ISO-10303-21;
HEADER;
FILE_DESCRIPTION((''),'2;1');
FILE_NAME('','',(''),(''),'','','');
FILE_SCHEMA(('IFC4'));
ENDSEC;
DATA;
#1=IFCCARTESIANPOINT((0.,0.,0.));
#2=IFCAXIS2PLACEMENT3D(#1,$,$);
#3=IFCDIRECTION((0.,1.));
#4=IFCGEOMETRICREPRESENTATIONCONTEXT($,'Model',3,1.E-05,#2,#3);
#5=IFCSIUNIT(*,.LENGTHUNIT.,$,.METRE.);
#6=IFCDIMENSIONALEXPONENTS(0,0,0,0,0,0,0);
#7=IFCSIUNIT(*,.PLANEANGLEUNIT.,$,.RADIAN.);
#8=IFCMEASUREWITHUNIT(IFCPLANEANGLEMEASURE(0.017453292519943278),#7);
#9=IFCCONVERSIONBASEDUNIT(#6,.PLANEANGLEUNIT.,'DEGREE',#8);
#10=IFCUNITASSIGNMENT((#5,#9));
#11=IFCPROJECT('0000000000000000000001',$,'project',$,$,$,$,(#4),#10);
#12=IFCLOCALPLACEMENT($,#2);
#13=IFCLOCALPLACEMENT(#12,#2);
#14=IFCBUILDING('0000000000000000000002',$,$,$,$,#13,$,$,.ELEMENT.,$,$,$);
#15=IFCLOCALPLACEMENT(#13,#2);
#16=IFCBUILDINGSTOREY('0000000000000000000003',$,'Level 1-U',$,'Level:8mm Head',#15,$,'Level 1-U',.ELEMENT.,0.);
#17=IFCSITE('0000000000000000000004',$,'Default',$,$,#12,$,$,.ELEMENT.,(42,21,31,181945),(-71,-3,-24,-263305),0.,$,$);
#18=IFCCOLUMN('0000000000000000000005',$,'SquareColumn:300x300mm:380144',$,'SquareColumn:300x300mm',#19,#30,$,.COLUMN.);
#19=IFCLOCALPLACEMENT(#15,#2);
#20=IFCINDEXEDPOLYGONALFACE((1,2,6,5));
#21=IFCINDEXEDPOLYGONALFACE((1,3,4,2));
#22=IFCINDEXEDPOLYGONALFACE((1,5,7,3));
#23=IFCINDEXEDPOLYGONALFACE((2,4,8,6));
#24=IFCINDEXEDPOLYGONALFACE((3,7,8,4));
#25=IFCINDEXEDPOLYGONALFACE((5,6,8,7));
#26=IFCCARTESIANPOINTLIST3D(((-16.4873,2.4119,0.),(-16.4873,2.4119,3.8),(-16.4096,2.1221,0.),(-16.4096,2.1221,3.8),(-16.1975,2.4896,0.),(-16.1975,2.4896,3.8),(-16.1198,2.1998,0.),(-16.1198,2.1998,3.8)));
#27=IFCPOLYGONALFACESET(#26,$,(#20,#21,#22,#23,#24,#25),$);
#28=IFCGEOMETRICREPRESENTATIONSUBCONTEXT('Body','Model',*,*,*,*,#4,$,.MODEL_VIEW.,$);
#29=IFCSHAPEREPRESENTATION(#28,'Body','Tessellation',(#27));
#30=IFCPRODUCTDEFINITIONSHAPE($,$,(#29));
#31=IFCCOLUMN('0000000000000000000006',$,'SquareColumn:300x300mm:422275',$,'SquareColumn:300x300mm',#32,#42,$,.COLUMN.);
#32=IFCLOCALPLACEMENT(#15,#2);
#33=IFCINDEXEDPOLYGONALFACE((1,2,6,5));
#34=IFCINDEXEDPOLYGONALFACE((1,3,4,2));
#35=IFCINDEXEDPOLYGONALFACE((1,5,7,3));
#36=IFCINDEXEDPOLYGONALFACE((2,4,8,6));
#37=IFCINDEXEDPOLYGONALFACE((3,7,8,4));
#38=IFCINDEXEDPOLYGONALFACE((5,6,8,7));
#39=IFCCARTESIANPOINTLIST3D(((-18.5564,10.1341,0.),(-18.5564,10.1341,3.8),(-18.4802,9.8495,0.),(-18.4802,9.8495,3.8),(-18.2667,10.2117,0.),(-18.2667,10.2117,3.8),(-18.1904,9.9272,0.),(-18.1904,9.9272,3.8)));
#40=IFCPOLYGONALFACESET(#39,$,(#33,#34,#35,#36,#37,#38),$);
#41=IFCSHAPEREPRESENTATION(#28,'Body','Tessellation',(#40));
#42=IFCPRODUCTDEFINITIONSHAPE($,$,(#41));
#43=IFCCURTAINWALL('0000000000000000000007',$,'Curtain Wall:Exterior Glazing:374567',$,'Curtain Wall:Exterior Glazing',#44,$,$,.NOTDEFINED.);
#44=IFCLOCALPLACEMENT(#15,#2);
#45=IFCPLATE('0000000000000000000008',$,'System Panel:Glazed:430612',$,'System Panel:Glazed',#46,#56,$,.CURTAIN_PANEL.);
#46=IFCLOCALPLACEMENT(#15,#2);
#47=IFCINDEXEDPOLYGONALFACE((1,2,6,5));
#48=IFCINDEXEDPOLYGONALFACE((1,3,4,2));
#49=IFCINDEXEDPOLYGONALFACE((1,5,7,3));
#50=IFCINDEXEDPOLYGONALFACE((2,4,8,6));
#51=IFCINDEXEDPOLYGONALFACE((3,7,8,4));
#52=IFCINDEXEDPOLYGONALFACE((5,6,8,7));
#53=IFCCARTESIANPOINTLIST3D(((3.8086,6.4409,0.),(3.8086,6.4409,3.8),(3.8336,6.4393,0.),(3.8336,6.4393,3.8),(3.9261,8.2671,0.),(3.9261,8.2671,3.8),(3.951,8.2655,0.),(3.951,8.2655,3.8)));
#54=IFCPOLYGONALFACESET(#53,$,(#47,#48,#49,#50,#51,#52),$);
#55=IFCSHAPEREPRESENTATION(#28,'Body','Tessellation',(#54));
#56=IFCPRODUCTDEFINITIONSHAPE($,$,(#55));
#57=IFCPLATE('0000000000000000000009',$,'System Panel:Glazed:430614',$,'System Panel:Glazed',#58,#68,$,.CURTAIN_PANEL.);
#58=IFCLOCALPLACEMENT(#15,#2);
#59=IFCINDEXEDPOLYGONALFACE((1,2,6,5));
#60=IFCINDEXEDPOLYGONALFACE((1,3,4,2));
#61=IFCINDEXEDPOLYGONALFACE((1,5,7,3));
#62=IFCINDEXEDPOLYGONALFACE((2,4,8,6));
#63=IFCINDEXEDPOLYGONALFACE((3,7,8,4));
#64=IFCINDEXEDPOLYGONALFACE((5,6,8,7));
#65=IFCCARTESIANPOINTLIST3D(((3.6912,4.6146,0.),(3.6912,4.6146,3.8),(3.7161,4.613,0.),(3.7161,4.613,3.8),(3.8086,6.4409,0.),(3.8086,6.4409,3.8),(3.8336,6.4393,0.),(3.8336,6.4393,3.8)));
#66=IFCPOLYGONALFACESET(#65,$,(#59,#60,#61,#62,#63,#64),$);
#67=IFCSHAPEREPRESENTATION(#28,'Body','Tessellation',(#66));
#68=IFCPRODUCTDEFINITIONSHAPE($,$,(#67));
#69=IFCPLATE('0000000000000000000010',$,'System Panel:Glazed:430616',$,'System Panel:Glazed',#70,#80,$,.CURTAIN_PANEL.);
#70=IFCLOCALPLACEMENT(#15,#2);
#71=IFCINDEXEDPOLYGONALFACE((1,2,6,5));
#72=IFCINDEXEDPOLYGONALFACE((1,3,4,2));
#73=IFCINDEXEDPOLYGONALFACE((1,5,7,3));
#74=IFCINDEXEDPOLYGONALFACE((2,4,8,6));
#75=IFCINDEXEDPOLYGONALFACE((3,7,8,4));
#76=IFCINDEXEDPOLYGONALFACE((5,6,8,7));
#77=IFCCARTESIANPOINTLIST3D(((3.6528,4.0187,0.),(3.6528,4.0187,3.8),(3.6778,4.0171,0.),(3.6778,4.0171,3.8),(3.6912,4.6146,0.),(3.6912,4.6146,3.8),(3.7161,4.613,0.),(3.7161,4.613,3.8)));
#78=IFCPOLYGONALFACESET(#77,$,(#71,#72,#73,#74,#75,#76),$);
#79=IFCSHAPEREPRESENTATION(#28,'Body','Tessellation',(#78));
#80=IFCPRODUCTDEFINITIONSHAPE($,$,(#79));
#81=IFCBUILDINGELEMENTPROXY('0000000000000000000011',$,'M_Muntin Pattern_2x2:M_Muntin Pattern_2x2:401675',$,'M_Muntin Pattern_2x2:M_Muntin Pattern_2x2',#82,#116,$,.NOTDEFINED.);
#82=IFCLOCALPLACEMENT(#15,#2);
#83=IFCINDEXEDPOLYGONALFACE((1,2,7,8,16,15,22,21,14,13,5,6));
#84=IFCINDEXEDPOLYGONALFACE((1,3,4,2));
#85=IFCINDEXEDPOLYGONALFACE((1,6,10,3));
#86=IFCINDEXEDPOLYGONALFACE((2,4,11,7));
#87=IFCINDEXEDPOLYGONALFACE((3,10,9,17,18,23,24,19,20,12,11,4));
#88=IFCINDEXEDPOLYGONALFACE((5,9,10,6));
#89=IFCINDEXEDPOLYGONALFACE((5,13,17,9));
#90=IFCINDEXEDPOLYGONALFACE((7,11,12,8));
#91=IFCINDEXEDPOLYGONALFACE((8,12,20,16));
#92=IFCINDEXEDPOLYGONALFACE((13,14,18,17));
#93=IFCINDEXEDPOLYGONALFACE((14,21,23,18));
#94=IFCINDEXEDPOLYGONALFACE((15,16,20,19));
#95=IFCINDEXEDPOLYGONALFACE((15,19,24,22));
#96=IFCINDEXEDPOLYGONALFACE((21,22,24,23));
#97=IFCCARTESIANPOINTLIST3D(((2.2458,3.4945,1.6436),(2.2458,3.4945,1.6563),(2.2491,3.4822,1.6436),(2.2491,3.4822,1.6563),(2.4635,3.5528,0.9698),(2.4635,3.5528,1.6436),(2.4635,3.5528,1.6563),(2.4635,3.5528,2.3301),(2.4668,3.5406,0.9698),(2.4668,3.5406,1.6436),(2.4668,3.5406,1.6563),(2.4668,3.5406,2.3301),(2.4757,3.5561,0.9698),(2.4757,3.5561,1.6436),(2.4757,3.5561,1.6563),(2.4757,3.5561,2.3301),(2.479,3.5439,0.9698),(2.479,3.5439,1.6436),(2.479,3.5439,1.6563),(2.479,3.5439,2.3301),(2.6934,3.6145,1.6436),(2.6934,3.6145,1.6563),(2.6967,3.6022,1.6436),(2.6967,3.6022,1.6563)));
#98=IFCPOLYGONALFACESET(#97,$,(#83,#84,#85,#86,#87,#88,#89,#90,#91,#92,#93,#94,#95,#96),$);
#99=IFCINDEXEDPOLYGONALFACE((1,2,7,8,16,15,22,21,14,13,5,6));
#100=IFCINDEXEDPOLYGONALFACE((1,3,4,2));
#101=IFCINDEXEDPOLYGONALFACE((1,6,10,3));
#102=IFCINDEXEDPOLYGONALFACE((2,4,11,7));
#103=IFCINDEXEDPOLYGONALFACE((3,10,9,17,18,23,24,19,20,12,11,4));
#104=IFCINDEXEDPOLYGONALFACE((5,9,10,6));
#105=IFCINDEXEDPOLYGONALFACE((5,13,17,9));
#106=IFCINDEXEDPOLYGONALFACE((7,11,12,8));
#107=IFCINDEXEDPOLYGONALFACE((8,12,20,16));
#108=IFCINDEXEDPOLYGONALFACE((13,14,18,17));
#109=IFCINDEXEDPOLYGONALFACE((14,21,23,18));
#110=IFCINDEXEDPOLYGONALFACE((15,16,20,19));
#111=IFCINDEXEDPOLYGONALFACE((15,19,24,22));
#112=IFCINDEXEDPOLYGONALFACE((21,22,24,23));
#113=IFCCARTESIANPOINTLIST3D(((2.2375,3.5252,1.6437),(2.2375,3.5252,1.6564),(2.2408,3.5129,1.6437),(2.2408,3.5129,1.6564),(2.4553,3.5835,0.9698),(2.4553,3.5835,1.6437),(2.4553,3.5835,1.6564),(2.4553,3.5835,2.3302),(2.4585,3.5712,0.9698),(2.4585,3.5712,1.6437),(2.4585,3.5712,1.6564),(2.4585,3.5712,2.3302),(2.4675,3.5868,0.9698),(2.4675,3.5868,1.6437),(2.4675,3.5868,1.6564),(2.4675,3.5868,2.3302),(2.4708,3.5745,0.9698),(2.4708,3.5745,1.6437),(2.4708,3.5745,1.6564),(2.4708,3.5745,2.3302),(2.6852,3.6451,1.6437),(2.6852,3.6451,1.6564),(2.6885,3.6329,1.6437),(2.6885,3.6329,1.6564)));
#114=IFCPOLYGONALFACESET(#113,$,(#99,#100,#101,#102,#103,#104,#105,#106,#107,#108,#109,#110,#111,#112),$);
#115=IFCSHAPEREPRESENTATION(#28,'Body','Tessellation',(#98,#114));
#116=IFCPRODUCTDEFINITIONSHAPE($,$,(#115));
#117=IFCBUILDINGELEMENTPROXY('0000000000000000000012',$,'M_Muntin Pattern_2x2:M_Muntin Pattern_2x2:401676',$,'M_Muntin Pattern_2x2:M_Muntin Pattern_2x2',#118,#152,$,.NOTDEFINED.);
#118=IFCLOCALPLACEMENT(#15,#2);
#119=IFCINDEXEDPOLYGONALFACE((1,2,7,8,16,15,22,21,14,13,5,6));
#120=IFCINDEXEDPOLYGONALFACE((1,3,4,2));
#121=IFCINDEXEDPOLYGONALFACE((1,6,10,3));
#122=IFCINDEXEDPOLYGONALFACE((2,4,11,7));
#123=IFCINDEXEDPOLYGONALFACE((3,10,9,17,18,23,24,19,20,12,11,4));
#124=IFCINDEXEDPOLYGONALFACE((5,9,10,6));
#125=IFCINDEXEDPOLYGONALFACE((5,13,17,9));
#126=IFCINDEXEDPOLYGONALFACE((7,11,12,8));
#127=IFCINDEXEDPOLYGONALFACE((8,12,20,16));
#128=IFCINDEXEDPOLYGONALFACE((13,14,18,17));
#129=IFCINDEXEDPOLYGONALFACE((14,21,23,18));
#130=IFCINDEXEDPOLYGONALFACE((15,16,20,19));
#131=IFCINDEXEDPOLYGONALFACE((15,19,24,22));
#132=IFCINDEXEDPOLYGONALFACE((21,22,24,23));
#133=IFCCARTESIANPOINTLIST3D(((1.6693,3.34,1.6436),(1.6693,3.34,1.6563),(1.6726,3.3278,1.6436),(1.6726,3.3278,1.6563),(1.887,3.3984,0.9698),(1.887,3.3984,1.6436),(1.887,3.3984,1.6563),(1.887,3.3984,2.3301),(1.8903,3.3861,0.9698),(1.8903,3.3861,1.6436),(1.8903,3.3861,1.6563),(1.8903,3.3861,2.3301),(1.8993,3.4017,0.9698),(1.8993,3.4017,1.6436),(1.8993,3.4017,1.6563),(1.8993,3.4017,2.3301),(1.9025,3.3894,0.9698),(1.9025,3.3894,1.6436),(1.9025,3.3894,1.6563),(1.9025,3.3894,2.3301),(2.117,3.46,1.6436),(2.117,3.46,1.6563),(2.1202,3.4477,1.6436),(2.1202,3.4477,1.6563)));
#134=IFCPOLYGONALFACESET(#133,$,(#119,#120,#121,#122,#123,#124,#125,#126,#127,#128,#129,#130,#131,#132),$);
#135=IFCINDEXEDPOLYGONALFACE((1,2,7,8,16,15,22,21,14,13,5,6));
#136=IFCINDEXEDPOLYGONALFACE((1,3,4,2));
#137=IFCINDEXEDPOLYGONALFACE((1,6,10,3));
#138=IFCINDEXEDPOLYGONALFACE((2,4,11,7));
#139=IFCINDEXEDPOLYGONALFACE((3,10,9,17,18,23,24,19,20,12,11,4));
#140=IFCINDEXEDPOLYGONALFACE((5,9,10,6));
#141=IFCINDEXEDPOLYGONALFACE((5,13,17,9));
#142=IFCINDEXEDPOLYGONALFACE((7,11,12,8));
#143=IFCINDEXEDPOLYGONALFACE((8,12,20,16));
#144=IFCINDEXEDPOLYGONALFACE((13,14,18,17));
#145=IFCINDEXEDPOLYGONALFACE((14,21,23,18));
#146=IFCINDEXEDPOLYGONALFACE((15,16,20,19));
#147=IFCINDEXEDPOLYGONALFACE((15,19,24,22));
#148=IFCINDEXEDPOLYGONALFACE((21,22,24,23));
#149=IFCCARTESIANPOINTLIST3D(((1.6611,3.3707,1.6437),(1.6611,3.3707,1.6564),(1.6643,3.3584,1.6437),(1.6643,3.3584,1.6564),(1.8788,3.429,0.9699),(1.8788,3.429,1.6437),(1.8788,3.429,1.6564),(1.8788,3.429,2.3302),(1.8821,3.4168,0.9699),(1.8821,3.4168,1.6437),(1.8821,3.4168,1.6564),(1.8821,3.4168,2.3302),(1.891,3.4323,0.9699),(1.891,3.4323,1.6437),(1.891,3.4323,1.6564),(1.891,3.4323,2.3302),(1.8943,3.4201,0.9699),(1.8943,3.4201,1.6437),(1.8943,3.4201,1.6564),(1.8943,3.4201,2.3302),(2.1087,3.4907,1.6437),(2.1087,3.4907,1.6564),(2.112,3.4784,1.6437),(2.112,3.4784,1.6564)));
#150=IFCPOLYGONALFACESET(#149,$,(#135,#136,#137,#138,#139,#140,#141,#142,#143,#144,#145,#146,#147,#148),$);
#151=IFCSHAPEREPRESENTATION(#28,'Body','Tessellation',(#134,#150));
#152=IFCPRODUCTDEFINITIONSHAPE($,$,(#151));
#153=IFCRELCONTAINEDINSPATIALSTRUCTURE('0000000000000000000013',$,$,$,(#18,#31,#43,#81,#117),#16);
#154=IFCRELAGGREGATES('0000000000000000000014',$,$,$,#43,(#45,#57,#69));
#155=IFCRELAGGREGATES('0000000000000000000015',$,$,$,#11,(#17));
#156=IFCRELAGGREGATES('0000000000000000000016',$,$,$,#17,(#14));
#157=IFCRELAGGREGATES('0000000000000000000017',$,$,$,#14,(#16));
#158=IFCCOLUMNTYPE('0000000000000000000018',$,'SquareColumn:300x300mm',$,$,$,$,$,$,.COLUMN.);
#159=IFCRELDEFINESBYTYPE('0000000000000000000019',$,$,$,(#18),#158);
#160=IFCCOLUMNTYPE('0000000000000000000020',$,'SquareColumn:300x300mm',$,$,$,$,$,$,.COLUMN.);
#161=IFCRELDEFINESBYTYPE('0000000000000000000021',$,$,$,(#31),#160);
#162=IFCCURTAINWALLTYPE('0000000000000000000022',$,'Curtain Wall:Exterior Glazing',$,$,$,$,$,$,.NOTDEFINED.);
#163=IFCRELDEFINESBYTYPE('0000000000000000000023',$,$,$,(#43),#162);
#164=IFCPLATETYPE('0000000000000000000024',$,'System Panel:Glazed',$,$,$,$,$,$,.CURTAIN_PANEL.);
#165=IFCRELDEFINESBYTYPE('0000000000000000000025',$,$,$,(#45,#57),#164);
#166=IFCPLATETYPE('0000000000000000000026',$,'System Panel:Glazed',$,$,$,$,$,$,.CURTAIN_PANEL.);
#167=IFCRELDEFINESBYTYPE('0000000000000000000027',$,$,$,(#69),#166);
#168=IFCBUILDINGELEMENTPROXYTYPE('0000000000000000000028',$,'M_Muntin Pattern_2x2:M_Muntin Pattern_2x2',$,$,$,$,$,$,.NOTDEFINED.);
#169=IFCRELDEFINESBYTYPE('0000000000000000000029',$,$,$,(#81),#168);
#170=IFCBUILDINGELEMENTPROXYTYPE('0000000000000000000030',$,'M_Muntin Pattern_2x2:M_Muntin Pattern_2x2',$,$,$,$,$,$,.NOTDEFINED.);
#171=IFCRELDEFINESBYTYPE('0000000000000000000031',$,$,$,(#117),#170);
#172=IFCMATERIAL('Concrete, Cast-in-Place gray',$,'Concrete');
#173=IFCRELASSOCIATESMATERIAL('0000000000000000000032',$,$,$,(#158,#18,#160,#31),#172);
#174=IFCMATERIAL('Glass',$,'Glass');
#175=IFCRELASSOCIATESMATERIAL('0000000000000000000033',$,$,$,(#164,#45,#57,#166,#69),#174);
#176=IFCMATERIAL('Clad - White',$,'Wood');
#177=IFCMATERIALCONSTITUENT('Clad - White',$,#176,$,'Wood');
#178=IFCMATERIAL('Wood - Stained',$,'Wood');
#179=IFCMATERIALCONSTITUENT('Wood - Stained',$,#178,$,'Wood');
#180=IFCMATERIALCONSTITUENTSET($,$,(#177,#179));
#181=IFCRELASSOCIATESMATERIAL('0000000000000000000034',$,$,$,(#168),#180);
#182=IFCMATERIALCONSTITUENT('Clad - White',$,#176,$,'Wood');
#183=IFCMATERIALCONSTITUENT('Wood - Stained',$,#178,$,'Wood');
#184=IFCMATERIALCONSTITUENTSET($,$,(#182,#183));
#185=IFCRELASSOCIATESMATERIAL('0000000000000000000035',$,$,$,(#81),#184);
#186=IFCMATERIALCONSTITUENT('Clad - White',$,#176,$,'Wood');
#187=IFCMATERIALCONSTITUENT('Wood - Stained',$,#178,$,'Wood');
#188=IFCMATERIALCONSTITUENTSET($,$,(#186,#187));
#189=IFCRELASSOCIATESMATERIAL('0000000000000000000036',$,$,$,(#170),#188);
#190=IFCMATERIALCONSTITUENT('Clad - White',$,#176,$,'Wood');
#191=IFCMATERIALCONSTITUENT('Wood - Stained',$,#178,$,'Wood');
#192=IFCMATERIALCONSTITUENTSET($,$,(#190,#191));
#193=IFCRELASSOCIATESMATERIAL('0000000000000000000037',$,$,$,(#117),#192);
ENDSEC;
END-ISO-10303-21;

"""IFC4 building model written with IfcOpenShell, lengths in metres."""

from ifc_helpers import new_model, entity, si_unit, converted_unit, direction, frame, origin, place, context, subcontext, project, spatial, indexed_curve, outline, extrude, source, transform, mapped, material, constituent, constituent_set, type_object, type_shapes, element, aggregate, save


model = new_model("IFC4")

# Units and contexts
model_context = context("Model", 3, precision=1e-05, world=origin(), true_north=direction((0.0, 1.0)))
body_context = subcontext(model_context, "Body", "Model", "MODEL_VIEW")
ifc_project = project(units=[si_unit("LENGTHUNIT", "METRE"), converted_unit("PLANEANGLEUNIT", "DEGREE", entity("IfcPlaneAngleMeasure", 0.017453292519943278), si_unit("PLANEANGLEUNIT", "RADIAN"), dimensions=[0, 0, 0, 0, 0, 0, 0])], contexts=[model_context])

# Site, building, storey
site_placement = place(None, origin())
site = spatial("IfcSite", under=ifc_project, at=site_placement, Name="Default", CompositionType="ELEMENT", RefLatitude=(42, 21, 31, 181945), RefLongitude=(-71, -3, -24, -263305), RefElevation=0.0)
building_placement = place(site_placement, origin())
building = spatial("IfcBuilding", under=site, at=building_placement, CompositionType="ELEMENT")
storey_placement = place(building_placement, origin())
storey = spatial("IfcBuildingStorey", under=building, at=storey_placement, Name="Level 1-U", ObjectType="Level:8mm Head", LongName="Level 1-U", CompositionType="ELEMENT", Elevation=0.0)

# Columns
ifc_material_1 = material(Name="Concrete, Cast-in-Place gray", Category="Concrete")
column_type_1 = type_object("IfcColumnType", Name="SquareColumn:300x300mm", PredefinedType="COLUMN", material=ifc_material_1)
shared_shape_1 = source(origin(), body_context, "Body", "SweptSolid", [
    extrude(outline(indexed_curve([(-0.15, -0.15), (0.15, -0.15), (0.15, 0.15), (-0.15, 0.15), (-0.15, -0.15)], self_intersect=False)), frame((-16.3036, 2.3058, 0.0), z_axis=(0.0, 0.0, 1.0), x_axis=(-0.258819, 0.965926, 0.0)), (0.0, 0.0, 1.0), 3.8),
])
type_shapes(column_type_1, [shared_shape_1])
column_1_placement = place(storey_placement, origin())
element("IfcColumn", 1, at=column_1_placement, inside=storey, type_object=column_type_1, material=ifc_material_1, Name="SquareColumn:300x300mm:380144", ObjectType="SquareColumn:300x300mm", PredefinedType="COLUMN", context=body_context, shape_type="MappedRepresentation", body=[
    mapped(shared_shape_1, transform((0.0, 0.0, 0.0), scale=1.0)),
])
column_type_2 = type_object("IfcColumnType", Name="SquareColumn:300x300mm", PredefinedType="COLUMN", material=ifc_material_1)
shared_shape_2 = source(origin(), body_context, "Body", "SweptSolid", [
    extrude(outline(indexed_curve([(-0.1473, -0.15), (0.1473, -0.15), (0.1473, 0.15), (-0.1473, 0.15), (-0.1473, -0.15)], self_intersect=False)), frame((-18.3734, 10.0306, 0.0), z_axis=(0.0, 0.0, 1.0), x_axis=(-0.258819, 0.965926, 0.0)), (0.0, 0.0, 1.0), 3.8),
])
type_shapes(column_type_2, [shared_shape_2])
column_2_placement = place(storey_placement, origin())
element("IfcColumn", 2, at=column_2_placement, inside=storey, type_object=column_type_2, material=ifc_material_1, Name="SquareColumn:300x300mm:422275", ObjectType="SquareColumn:300x300mm", PredefinedType="COLUMN", context=body_context, shape_type="MappedRepresentation", body=[
    mapped(shared_shape_2, transform((0.0, 0.0, 0.0), scale=1.0)),
])

# Curtain wall, plates
curtain_wall_type = type_object("IfcCurtainWallType", Name="Curtain Wall:Exterior Glazing", PredefinedType="NOTDEFINED")
curtain_wall_placement = place(storey_placement, origin())
curtain_wall = element("IfcCurtainWall", 3, at=curtain_wall_placement, inside=storey, type_object=curtain_wall_type, Name="Curtain Wall:Exterior Glazing:374567", ObjectType="Curtain Wall:Exterior Glazing", PredefinedType="NOTDEFINED")
ifc_material_2 = material(Name="Glass", Category="Glass")
plate_type_1 = type_object("IfcPlateType", Name="System Panel:Glazed", PredefinedType="CURTAIN_PANEL", material=ifc_material_2)
shared_shape_3 = source(origin(), body_context, "Body", "SweptSolid", [
    extrude(outline(indexed_curve([(-0.0125, -0.915), (0.0125, -0.915), (0.0125, 0.915), (-0.0125, 0.915), (-0.0125, -0.915)], self_intersect=False)), frame((0.0, 0.037, 0.0), z_axis=(0.0, 0.0, 1.0), x_axis=(0.0, 1.0, 0.0)), (0.0, 0.0, 1.0), 3.8),
])
type_shapes(plate_type_1, [shared_shape_3])
plate_1_placement = place(curtain_wall_placement, frame((3.8429, 7.3555, 0.0), z_axis=(0.0, 0.0, 1.0), x_axis=(-0.064186, -0.997938, 0.0)))
plate_1 = element("IfcPlate", 4, at=plate_1_placement, type_object=plate_type_1, material=ifc_material_2, Name="System Panel:Glazed:430612", ObjectType="System Panel:Glazed", PredefinedType="CURTAIN_PANEL", context=body_context, shape_type="MappedRepresentation", body=[
    mapped(shared_shape_3, transform((0.0, 0.0, 0.0), scale=1.0)),
])
plate_2_placement = place(curtain_wall_placement, frame((3.7254, 5.5293, 0.0), z_axis=(0.0, 0.0, 1.0), x_axis=(-0.064186, -0.997938, 0.0)))
plate_2 = element("IfcPlate", 5, at=plate_2_placement, type_object=plate_type_1, material=ifc_material_2, Name="System Panel:Glazed:430614", ObjectType="System Panel:Glazed", PredefinedType="CURTAIN_PANEL", context=body_context, shape_type="MappedRepresentation", body=[
    mapped(shared_shape_3, transform((0.0, 0.0, 0.0), scale=1.0)),
])
plate_type_2 = type_object("IfcPlateType", Name="System Panel:Glazed", PredefinedType="CURTAIN_PANEL", material=ifc_material_2)
shared_shape_4 = source(origin(), body_context, "Body", "SweptSolid", [
    extrude(outline(indexed_curve([(-0.0125, -0.2986), (0.0125, -0.2986), (0.0125, 0.2986), (-0.0125, 0.2986), (-0.0125, -0.2986)], self_intersect=False)), frame((0.0, 0.037, 0.0), z_axis=(0.0, 0.0, 1.0), x_axis=(0.0, 1.0, 0.0)), (0.0, 0.0, 1.0), 3.8),
])
type_shapes(plate_type_2, [shared_shape_4])
plate_3_placement = place(curtain_wall_placement, frame((3.6475, 4.3182, 0.0), z_axis=(0.0, 0.0, 1.0), x_axis=(-0.064186, -0.997938, 0.0)))
plate_3 = element("IfcPlate", 6, at=plate_3_placement, type_object=plate_type_2, material=ifc_material_2, Name="System Panel:Glazed:430616", ObjectType="System Panel:Glazed", PredefinedType="CURTAIN_PANEL", context=body_context, shape_type="MappedRepresentation", body=[
    mapped(shared_shape_4, transform((0.0, 0.0, 0.0), scale=1.0)),
])
aggregate(curtain_wall, [plate_1, plate_2, plate_3])

# Building element proxies
ifc_material_3 = material(Name="Clad - White", Category="Wood")
ifc_constituent_1 = constituent(ifc_material_3, Name="Clad - White", Category="Wood")
ifc_material_4 = material(Name="Wood - Stained", Category="Wood")
ifc_constituent_2 = constituent(ifc_material_4, Name="Wood - Stained", Category="Wood")
ifc_constituent_set_1 = constituent_set(constituents=[ifc_constituent_1, ifc_constituent_2])
ifc_constituent_3 = constituent(ifc_material_3, Name="Clad - White", Category="Wood")
ifc_constituent_4 = constituent(ifc_material_4, Name="Wood - Stained", Category="Wood")
ifc_constituent_set_2 = constituent_set(constituents=[ifc_constituent_3, ifc_constituent_4])
building_element_proxy_type_1 = type_object("IfcBuildingElementProxyType", Name="M_Muntin Pattern_2x2:M_Muntin Pattern_2x2", PredefinedType="NOTDEFINED", material=ifc_constituent_set_2)
shared_shape_5 = source(origin(), body_context, "Body", "SweptSolid", [
    extrude(outline(indexed_curve([(0.0064, -0.0064), (0.6801, -0.0064), (0.6801, 0.0063), (0.0064, 0.0063), (0.0064, 0.2317), (-0.0063, 0.2317), (-0.0063, 0.0063), (-0.6802, 0.0063), (-0.6802, -0.0064), (-0.0063, -0.0064), (-0.0063, -0.2317), (0.0064, -0.2317), (0.0064, -0.0064)], self_intersect=False)), frame((0.0, 0.0095, 0.6801), z_axis=(0.0, 1.0, 0.0), x_axis=(0.0, 0.0, 1.0)), (0.0, 0.0, 1.0), 0.0127),
    extrude(outline(indexed_curve([(0.0064, -0.0064), (0.6802, -0.0064), (0.6802, 0.0063), (0.0064, 0.0063), (0.0064, 0.2317), (-0.0063, 0.2317), (-0.0063, 0.0063), (-0.6802, 0.0063), (-0.6802, -0.0064), (-0.0063, -0.0064), (-0.0063, -0.2317), (0.0064, -0.2317), (0.0064, -0.0064)], self_intersect=False)), frame((0.0, -0.0222, 0.6802), z_axis=(0.0, 1.0, 0.0), x_axis=(0.0, 0.0, 1.0)), (0.0, 0.0, 1.0), 0.0127),
])
type_shapes(building_element_proxy_type_1, [shared_shape_5])
proxy_1_placement = place(storey_placement, frame((2.4671, 3.5637, 0.9698), z_axis=(0.0, 0.0, 1.0), x_axis=(-0.965926, -0.258819, 0.0)))
element("IfcBuildingElementProxy", 7, at=proxy_1_placement, inside=storey, type_object=building_element_proxy_type_1, material=ifc_constituent_set_1, Name="M_Muntin Pattern_2x2:M_Muntin Pattern_2x2:401675", ObjectType="M_Muntin Pattern_2x2:M_Muntin Pattern_2x2", PredefinedType="NOTDEFINED", context=body_context, shape_type="MappedRepresentation", body=[
    mapped(shared_shape_5, transform((0.0, 0.0, 0.0), scale=1.0)),
])
ifc_constituent_5 = constituent(ifc_material_3, Name="Clad - White", Category="Wood")
ifc_constituent_6 = constituent(ifc_material_4, Name="Wood - Stained", Category="Wood")
ifc_constituent_set_3 = constituent_set(constituents=[ifc_constituent_5, ifc_constituent_6])
ifc_constituent_7 = constituent(ifc_material_3, Name="Clad - White", Category="Wood")
ifc_constituent_8 = constituent(ifc_material_4, Name="Wood - Stained", Category="Wood")
ifc_constituent_set_4 = constituent_set(constituents=[ifc_constituent_7, ifc_constituent_8])
building_element_proxy_type_2 = type_object("IfcBuildingElementProxyType", Name="M_Muntin Pattern_2x2:M_Muntin Pattern_2x2", PredefinedType="NOTDEFINED", material=ifc_constituent_set_4)
shared_shape_6 = source(origin(), body_context, "Body", "SweptSolid", [
    extrude(outline(indexed_curve([(0.0064, -0.0064), (0.6801, -0.0064), (0.6801, 0.0063), (0.0064, 0.0063), (0.0064, 0.2317), (-0.0063, 0.2317), (-0.0063, 0.0063), (-0.6802, 0.0063), (-0.6802, -0.0064), (-0.0063, -0.0064), (-0.0063, -0.2317), (0.0064, -0.2317), (0.0064, -0.0064)], self_intersect=False)), frame((0.0, -0.0222, 0.6801), z_axis=(0.0, 1.0, 0.0), x_axis=(0.0, 0.0, 1.0)), (0.0, 0.0, 1.0), 0.0127),
    extrude(outline(indexed_curve([(0.0064, -0.0064), (0.6802, -0.0064), (0.6802, 0.0063), (0.0064, 0.0063), (0.0064, 0.2317), (-0.0063, 0.2317), (-0.0063, 0.0063), (-0.6802, 0.0063), (-0.6802, -0.0064), (-0.0063, -0.0064), (-0.0063, -0.2317), (0.0064, -0.2317), (0.0064, -0.0064)], self_intersect=False)), frame((0.0, 0.0095, 0.6802), z_axis=(0.0, 1.0, 0.0), x_axis=(0.0, 0.0, 1.0)), (0.0, 0.0, 1.0), 0.0127),
])
type_shapes(building_element_proxy_type_2, [shared_shape_6])
proxy_2_placement = place(storey_placement, frame((1.8907, 3.4092, 0.9699), z_axis=(0.0, 0.0, 1.0), x_axis=(0.965926, 0.258819, 0.0)))
element("IfcBuildingElementProxy", 8, at=proxy_2_placement, inside=storey, type_object=building_element_proxy_type_2, material=ifc_constituent_set_3, Name="M_Muntin Pattern_2x2:M_Muntin Pattern_2x2:401676", ObjectType="M_Muntin Pattern_2x2:M_Muntin Pattern_2x2", PredefinedType="NOTDEFINED", context=body_context, shape_type="MappedRepresentation", body=[
    mapped(shared_shape_6, transform((0.0, 0.0, 0.0), scale=1.0)),
])

save(model, "model.ifc")
